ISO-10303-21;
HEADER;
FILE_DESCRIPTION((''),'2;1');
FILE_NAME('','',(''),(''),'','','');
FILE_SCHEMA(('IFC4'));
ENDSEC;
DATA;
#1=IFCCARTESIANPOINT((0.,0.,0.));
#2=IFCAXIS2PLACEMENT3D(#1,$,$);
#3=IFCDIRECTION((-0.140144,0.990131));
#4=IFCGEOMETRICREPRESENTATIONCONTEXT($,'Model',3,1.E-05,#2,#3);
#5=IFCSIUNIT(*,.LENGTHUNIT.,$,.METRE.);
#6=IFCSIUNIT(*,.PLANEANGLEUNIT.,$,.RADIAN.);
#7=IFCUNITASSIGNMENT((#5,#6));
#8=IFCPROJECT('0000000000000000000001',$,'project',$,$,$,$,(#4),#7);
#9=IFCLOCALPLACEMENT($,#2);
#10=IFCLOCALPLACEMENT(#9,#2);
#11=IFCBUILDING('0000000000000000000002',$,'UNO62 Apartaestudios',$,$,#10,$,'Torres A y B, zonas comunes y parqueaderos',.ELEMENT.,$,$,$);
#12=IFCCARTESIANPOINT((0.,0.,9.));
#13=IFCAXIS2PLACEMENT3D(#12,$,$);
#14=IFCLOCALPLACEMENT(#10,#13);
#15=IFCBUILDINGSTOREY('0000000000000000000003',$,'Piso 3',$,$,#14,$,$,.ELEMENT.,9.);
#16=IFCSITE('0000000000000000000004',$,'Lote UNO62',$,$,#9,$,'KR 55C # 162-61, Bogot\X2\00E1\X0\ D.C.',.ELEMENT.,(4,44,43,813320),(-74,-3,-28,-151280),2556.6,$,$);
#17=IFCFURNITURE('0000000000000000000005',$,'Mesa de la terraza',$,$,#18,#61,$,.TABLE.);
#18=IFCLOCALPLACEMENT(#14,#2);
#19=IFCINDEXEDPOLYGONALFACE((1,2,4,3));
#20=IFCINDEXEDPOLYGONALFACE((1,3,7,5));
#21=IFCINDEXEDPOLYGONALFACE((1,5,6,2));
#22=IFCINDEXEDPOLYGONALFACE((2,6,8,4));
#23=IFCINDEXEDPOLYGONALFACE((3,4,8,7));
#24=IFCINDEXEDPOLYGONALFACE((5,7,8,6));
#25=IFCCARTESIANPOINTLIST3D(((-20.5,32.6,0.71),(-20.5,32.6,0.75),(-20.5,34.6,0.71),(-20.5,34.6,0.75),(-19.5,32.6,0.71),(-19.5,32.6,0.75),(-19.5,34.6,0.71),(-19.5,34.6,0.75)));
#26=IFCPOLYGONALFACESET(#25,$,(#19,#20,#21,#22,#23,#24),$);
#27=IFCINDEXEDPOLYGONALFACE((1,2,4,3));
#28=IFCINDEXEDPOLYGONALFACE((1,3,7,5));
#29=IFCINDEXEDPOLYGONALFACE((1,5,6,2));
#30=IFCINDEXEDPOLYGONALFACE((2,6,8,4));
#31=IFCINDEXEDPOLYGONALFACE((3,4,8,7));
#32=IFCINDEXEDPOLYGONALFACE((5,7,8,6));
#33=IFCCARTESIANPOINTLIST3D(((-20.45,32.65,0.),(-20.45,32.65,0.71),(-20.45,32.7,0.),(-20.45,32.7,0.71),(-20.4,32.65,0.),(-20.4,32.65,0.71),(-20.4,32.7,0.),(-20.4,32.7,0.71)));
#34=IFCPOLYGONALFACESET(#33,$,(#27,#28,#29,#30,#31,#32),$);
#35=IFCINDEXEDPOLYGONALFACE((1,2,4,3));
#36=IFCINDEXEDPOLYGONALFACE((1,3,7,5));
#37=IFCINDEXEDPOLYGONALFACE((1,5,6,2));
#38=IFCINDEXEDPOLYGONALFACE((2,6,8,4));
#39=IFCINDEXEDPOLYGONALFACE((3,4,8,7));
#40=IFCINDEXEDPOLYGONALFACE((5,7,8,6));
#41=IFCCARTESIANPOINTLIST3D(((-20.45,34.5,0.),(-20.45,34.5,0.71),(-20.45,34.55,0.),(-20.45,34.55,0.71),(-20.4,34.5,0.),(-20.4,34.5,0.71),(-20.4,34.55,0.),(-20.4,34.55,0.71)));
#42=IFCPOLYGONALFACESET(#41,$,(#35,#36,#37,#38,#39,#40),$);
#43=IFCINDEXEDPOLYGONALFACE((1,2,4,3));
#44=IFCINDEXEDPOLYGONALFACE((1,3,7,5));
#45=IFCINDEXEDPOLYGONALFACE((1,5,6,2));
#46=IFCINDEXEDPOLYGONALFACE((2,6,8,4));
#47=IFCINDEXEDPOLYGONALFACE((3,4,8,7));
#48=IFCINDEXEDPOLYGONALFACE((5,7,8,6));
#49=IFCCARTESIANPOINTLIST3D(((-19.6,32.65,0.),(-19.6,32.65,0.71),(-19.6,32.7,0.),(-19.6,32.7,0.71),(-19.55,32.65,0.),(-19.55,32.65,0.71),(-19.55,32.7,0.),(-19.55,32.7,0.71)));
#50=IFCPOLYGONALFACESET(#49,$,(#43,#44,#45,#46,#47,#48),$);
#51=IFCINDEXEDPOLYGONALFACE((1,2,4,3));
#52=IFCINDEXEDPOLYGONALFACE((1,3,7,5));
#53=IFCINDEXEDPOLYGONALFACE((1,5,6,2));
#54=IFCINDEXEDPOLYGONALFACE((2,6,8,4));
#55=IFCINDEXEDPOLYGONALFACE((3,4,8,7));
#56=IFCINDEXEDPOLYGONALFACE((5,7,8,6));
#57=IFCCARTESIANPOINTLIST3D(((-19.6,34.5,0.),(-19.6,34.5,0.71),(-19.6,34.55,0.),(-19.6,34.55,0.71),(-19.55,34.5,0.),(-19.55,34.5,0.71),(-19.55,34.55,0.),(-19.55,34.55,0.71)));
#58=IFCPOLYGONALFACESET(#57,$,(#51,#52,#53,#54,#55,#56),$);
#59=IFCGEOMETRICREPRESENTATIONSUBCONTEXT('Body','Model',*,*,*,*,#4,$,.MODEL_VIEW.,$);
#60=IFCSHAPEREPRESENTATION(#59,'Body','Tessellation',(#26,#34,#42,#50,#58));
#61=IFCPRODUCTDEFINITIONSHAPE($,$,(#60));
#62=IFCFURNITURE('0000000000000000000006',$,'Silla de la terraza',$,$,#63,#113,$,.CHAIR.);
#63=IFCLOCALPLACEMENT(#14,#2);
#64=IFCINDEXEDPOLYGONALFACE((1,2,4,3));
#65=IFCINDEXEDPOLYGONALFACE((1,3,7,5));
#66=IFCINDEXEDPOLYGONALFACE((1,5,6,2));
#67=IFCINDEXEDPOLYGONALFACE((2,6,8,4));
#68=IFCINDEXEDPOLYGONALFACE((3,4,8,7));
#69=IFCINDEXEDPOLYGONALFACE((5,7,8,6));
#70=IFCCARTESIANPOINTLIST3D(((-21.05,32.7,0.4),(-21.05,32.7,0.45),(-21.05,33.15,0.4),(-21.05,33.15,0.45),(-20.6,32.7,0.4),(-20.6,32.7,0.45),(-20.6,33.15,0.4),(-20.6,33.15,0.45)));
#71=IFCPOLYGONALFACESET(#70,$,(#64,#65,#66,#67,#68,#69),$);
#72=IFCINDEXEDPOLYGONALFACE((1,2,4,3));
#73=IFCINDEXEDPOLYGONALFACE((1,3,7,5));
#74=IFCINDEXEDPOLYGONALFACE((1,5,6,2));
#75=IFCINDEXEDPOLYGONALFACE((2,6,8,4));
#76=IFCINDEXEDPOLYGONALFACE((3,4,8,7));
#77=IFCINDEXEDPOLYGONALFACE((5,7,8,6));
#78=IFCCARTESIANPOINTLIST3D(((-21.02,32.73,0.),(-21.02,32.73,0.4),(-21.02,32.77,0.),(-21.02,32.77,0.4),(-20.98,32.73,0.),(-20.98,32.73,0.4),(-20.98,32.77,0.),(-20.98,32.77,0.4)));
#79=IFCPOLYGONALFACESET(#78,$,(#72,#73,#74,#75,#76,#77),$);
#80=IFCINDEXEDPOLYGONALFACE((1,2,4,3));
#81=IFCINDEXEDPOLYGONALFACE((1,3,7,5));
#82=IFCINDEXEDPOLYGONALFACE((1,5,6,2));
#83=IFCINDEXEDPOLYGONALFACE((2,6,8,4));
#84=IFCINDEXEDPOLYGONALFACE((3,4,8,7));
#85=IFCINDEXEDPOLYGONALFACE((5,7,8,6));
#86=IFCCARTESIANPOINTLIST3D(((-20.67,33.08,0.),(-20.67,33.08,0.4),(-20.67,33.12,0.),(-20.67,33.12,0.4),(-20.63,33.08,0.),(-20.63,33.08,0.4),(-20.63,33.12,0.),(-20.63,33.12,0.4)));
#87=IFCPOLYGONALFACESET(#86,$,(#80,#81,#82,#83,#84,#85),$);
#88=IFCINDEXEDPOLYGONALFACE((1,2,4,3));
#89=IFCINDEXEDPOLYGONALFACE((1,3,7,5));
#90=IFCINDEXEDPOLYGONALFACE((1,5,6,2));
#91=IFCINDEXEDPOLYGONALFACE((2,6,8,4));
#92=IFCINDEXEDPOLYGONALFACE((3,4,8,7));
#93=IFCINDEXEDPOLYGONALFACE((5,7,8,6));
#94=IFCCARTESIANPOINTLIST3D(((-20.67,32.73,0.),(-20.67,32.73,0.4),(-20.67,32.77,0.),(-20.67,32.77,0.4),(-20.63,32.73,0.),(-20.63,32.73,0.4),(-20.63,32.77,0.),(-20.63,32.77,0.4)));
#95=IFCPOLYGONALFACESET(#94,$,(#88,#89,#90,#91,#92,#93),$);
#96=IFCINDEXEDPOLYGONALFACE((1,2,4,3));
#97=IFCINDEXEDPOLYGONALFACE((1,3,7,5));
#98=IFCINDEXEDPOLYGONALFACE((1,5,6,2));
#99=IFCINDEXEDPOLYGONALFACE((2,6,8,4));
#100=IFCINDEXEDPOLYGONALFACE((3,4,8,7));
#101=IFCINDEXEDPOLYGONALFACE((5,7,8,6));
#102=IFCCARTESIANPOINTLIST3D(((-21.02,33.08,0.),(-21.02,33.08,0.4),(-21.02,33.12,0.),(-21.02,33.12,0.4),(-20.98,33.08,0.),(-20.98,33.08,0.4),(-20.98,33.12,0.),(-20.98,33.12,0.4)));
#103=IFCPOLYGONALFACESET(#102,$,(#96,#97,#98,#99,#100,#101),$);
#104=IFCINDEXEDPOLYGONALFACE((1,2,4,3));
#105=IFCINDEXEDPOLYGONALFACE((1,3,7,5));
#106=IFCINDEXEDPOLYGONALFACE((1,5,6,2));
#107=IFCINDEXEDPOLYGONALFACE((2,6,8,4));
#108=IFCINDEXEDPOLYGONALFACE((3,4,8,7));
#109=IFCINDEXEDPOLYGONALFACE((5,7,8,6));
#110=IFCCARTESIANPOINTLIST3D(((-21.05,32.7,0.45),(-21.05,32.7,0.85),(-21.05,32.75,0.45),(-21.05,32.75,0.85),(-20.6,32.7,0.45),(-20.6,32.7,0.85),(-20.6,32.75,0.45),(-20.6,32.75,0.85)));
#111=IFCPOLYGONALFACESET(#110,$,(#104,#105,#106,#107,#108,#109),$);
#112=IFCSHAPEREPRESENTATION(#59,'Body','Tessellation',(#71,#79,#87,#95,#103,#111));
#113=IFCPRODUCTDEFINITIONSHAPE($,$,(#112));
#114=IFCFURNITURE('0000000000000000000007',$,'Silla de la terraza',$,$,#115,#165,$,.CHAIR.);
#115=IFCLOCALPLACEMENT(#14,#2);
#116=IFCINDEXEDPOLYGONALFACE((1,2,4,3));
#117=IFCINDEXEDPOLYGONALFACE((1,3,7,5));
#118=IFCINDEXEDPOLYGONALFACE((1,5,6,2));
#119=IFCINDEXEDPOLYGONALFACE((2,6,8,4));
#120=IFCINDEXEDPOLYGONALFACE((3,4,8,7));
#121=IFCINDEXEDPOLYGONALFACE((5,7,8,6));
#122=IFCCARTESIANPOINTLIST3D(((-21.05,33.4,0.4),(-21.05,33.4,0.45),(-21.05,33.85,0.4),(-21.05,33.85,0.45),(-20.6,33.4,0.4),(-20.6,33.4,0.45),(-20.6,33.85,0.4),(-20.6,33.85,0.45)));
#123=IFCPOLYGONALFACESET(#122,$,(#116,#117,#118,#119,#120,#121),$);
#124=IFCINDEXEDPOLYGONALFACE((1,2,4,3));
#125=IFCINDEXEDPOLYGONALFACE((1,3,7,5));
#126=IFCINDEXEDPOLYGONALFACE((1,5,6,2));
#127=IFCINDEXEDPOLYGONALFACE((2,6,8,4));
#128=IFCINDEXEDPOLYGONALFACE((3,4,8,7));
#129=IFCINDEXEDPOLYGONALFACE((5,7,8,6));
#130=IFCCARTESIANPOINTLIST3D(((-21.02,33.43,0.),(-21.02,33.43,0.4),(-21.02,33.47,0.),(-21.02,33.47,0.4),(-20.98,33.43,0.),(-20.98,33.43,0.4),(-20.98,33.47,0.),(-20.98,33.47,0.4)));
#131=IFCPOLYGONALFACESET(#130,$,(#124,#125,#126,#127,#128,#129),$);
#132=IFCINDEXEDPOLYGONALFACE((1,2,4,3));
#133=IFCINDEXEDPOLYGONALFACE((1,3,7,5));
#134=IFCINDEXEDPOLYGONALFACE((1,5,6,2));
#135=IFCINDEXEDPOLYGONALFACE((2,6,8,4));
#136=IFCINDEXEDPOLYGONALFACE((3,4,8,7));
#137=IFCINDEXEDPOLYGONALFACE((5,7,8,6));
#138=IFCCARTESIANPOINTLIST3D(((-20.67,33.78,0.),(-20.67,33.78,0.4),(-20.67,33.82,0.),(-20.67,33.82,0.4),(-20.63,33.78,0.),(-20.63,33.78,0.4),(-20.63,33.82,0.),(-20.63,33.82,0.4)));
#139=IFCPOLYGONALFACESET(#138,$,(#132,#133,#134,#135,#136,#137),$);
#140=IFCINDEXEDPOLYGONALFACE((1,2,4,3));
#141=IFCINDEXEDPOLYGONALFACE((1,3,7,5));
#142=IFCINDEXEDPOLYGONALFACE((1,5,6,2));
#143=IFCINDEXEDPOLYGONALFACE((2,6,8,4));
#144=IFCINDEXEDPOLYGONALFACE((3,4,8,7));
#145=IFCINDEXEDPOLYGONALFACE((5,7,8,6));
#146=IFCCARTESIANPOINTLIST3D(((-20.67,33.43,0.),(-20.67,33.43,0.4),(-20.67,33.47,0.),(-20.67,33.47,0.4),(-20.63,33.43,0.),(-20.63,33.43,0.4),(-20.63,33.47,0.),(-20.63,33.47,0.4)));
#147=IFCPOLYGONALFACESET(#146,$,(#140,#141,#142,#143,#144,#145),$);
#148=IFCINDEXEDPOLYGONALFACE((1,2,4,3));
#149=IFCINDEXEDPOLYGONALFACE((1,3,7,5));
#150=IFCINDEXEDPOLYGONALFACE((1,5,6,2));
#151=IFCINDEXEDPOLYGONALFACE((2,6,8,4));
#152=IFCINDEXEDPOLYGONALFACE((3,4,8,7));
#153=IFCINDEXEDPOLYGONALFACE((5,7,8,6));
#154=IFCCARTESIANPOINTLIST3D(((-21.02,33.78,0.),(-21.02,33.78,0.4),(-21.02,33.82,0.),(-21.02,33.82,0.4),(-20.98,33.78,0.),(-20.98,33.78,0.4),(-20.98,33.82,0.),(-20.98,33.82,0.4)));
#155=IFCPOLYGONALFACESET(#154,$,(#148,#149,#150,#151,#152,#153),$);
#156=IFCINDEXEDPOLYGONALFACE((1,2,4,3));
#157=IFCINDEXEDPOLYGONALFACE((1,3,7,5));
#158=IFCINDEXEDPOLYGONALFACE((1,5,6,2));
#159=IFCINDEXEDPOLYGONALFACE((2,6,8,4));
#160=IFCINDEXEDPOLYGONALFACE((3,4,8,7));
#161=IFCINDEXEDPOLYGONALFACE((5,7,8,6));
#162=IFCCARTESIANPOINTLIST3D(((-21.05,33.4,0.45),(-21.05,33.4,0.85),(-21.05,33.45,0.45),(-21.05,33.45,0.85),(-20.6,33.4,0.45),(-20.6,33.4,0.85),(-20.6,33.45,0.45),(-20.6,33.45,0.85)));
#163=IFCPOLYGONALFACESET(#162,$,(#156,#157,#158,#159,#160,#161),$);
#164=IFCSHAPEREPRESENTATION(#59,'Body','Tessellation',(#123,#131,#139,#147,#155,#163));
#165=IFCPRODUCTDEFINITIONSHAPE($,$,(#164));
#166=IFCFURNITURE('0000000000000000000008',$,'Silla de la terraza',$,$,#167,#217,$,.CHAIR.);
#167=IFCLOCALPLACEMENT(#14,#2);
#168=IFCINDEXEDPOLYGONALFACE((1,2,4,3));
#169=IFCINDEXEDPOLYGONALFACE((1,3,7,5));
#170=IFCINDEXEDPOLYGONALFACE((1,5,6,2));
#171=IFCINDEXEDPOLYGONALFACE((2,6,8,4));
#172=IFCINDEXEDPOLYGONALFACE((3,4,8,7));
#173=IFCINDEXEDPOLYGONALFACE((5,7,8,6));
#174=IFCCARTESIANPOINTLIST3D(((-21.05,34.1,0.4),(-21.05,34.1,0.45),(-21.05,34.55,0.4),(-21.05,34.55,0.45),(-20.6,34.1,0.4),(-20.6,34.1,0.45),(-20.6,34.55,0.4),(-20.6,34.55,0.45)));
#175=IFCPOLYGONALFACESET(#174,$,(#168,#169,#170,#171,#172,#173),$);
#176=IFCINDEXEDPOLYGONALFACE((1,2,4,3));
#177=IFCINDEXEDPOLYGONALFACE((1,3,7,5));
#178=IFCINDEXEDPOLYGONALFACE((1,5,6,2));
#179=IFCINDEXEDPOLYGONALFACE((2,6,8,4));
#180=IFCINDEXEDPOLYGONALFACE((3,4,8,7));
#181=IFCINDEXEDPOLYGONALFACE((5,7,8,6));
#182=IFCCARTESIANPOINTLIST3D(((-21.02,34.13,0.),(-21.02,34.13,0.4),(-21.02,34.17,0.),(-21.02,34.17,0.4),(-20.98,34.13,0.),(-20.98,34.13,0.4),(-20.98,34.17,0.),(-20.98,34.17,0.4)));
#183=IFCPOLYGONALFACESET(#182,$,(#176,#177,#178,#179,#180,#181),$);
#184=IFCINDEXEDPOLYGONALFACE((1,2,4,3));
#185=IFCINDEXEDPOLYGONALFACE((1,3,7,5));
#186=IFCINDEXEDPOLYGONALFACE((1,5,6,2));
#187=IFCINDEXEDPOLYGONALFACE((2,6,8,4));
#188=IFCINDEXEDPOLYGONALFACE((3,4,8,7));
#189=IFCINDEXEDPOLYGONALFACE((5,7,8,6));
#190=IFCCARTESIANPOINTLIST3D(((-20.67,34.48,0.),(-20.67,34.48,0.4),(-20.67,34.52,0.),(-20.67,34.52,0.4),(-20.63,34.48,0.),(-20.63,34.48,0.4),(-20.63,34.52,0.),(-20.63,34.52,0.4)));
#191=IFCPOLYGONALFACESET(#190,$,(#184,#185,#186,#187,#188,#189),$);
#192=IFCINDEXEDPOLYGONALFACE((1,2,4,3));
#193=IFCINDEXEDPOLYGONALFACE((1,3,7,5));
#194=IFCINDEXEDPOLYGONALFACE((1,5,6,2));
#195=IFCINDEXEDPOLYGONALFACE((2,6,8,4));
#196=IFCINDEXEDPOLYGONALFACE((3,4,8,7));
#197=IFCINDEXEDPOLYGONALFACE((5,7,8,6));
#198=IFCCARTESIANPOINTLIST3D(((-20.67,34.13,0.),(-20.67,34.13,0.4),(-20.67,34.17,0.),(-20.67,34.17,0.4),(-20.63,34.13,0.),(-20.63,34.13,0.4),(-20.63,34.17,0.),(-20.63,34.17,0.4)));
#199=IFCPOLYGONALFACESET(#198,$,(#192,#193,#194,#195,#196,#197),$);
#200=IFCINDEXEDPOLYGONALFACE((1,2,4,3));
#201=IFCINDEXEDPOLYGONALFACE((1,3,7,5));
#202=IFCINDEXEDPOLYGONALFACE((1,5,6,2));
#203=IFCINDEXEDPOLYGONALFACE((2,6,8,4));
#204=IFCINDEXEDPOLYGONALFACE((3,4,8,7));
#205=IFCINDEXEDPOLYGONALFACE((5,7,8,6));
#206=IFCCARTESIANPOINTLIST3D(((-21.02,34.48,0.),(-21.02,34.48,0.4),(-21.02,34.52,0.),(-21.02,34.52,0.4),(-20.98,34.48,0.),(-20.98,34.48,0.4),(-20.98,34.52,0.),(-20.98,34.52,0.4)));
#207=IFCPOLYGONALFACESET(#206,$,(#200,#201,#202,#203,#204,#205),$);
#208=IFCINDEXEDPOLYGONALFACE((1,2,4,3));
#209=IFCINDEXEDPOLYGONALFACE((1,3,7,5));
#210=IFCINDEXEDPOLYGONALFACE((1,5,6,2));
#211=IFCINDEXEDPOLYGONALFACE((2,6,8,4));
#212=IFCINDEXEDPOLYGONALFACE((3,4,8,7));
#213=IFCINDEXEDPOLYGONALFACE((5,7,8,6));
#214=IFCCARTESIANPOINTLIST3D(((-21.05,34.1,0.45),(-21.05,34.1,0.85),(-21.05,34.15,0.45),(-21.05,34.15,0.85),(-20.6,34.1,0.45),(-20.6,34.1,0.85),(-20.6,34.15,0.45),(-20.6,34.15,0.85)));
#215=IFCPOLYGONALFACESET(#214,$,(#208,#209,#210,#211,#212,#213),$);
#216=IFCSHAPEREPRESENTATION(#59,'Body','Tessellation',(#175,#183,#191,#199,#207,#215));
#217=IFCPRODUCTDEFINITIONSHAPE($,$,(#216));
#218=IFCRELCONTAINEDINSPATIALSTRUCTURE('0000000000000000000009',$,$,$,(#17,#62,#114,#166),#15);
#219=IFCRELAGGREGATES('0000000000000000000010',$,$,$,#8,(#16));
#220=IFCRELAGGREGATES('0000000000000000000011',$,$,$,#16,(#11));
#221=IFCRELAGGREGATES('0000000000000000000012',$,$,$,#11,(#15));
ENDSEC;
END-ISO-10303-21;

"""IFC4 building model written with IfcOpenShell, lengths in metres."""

from ifc_helpers import new_model, si_unit, direction, frame, frame_2d, origin, place, context, subcontext, project, spatial, rectangle, extrude, element, save


model = new_model("IFC4")

# Units and contexts
model_context = context("Model", 3, precision=1e-05, world=origin(), true_north=direction((-0.140144, 0.990131)))
body_context = subcontext(model_context, "Body", "Model", "MODEL_VIEW")
ifc_project = project(units=[si_unit("LENGTHUNIT", "METRE"), si_unit("PLANEANGLEUNIT", "RADIAN")], contexts=[model_context])

# Site, building, storey
site_placement = place(None, origin())
site = spatial("IfcSite", under=ifc_project, at=site_placement, Name="Lote UNO62", LongName="KR 55C # 162-61, Bogotá D.C.", CompositionType="ELEMENT", RefLatitude=(4, 44, 43, 813320), RefLongitude=(-74, -3, -28, -151280), RefElevation=2556.6)
building_placement = place(site_placement, origin())
building = spatial("IfcBuilding", under=site, at=building_placement, Name="UNO62 Apartaestudios", LongName="Torres A y B, zonas comunes y parqueaderos", CompositionType="ELEMENT")
storey_placement = place(building_placement, frame((0.0, 0.0, 9.0)))
storey = spatial("IfcBuildingStorey", under=building, at=storey_placement, Name="Piso 3", CompositionType="ELEMENT", Elevation=9.0)

# Furniture
furniture_1_placement = place(storey_placement, origin())
element("IfcFurniture", 1, at=furniture_1_placement, inside=storey, Name="Mesa de la terraza", PredefinedType="TABLE", context=body_context, shape_type="SweptSolid", body=[
    extrude(rectangle(XDim=1.0, YDim=2.0, at=frame_2d((-20.0, 33.6))), frame((0.0, 0.0, 0.71)), (0.0, 0.0, 1.0), 0.04),
    extrude(rectangle(XDim=0.05, YDim=0.05, at=frame_2d((-20.425, 32.675))), origin(), (0.0, 0.0, 1.0), 0.71),
    extrude(rectangle(XDim=0.05, YDim=0.05, at=frame_2d((-20.425, 34.525))), origin(), (0.0, 0.0, 1.0), 0.71),
    extrude(rectangle(XDim=0.05, YDim=0.05, at=frame_2d((-19.575, 32.675))), origin(), (0.0, 0.0, 1.0), 0.71),
    extrude(rectangle(XDim=0.05, YDim=0.05, at=frame_2d((-19.575, 34.525))), origin(), (0.0, 0.0, 1.0), 0.71),
])
furniture_2_placement = place(storey_placement, origin())
element("IfcFurniture", 2, at=furniture_2_placement, inside=storey, Name="Silla de la terraza", PredefinedType="CHAIR", context=body_context, shape_type="SweptSolid", body=[
    extrude(rectangle(XDim=0.45, YDim=0.45, at=frame_2d((-20.825, 32.925))), frame((0.0, 0.0, 0.4)), (0.0, 0.0, 1.0), 0.05),
    extrude(rectangle(XDim=0.04, YDim=0.04, at=frame_2d((-21.0, 32.75))), origin(), (0.0, 0.0, 1.0), 0.4),
    extrude(rectangle(XDim=0.04, YDim=0.04, at=frame_2d((-20.65, 33.1))), origin(), (0.0, 0.0, 1.0), 0.4),
    extrude(rectangle(XDim=0.04, YDim=0.04, at=frame_2d((-20.65, 32.75))), origin(), (0.0, 0.0, 1.0), 0.4),
    extrude(rectangle(XDim=0.04, YDim=0.04, at=frame_2d((-21.0, 33.1))), origin(), (0.0, 0.0, 1.0), 0.4),
    extrude(rectangle(XDim=0.45, YDim=0.05, at=frame_2d((-20.825, 32.725))), frame((0.0, 0.0, 0.45)), (0.0, 0.0, 1.0), 0.4),
])
furniture_3_placement = place(storey_placement, origin())
element("IfcFurniture", 3, at=furniture_3_placement, inside=storey, Name="Silla de la terraza", PredefinedType="CHAIR", context=body_context, shape_type="SweptSolid", body=[
    extrude(rectangle(XDim=0.45, YDim=0.45, at=frame_2d((-20.825, 33.625))), frame((0.0, 0.0, 0.4)), (0.0, 0.0, 1.0), 0.05),
    extrude(rectangle(XDim=0.04, YDim=0.04, at=frame_2d((-21.0, 33.45))), origin(), (0.0, 0.0, 1.0), 0.4),
    extrude(rectangle(XDim=0.04, YDim=0.04, at=frame_2d((-20.65, 33.8))), origin(), (0.0, 0.0, 1.0), 0.4),
    extrude(rectangle(XDim=0.04, YDim=0.04, at=frame_2d((-20.65, 33.45))), origin(), (0.0, 0.0, 1.0), 0.4),
    extrude(rectangle(XDim=0.04, YDim=0.04, at=frame_2d((-21.0, 33.8))), origin(), (0.0, 0.0, 1.0), 0.4),
    extrude(rectangle(XDim=0.45, YDim=0.05, at=frame_2d((-20.825, 33.425))), frame((0.0, 0.0, 0.45)), (0.0, 0.0, 1.0), 0.4),
])
furniture_4_placement = place(storey_placement, origin())
element("IfcFurniture", 4, at=furniture_4_placement, inside=storey, Name="Silla de la terraza", PredefinedType="CHAIR", context=body_context, shape_type="SweptSolid", body=[
    extrude(rectangle(XDim=0.45, YDim=0.45, at=frame_2d((-20.825, 34.325))), frame((0.0, 0.0, 0.4)), (0.0, 0.0, 1.0), 0.05),
    extrude(rectangle(XDim=0.04, YDim=0.04, at=frame_2d((-21.0, 34.15))), origin(), (0.0, 0.0, 1.0), 0.4),
    extrude(rectangle(XDim=0.04, YDim=0.04, at=frame_2d((-20.65, 34.5))), origin(), (0.0, 0.0, 1.0), 0.4),
    extrude(rectangle(XDim=0.04, YDim=0.04, at=frame_2d((-20.65, 34.15))), origin(), (0.0, 0.0, 1.0), 0.4),
    extrude(rectangle(XDim=0.04, YDim=0.04, at=frame_2d((-21.0, 34.5))), origin(), (0.0, 0.0, 1.0), 0.4),
    extrude(rectangle(XDim=0.45, YDim=0.05, at=frame_2d((-20.825, 34.125))), frame((0.0, 0.0, 0.45)), (0.0, 0.0, 1.0), 0.4),
])

save(model, "model.ifc")
